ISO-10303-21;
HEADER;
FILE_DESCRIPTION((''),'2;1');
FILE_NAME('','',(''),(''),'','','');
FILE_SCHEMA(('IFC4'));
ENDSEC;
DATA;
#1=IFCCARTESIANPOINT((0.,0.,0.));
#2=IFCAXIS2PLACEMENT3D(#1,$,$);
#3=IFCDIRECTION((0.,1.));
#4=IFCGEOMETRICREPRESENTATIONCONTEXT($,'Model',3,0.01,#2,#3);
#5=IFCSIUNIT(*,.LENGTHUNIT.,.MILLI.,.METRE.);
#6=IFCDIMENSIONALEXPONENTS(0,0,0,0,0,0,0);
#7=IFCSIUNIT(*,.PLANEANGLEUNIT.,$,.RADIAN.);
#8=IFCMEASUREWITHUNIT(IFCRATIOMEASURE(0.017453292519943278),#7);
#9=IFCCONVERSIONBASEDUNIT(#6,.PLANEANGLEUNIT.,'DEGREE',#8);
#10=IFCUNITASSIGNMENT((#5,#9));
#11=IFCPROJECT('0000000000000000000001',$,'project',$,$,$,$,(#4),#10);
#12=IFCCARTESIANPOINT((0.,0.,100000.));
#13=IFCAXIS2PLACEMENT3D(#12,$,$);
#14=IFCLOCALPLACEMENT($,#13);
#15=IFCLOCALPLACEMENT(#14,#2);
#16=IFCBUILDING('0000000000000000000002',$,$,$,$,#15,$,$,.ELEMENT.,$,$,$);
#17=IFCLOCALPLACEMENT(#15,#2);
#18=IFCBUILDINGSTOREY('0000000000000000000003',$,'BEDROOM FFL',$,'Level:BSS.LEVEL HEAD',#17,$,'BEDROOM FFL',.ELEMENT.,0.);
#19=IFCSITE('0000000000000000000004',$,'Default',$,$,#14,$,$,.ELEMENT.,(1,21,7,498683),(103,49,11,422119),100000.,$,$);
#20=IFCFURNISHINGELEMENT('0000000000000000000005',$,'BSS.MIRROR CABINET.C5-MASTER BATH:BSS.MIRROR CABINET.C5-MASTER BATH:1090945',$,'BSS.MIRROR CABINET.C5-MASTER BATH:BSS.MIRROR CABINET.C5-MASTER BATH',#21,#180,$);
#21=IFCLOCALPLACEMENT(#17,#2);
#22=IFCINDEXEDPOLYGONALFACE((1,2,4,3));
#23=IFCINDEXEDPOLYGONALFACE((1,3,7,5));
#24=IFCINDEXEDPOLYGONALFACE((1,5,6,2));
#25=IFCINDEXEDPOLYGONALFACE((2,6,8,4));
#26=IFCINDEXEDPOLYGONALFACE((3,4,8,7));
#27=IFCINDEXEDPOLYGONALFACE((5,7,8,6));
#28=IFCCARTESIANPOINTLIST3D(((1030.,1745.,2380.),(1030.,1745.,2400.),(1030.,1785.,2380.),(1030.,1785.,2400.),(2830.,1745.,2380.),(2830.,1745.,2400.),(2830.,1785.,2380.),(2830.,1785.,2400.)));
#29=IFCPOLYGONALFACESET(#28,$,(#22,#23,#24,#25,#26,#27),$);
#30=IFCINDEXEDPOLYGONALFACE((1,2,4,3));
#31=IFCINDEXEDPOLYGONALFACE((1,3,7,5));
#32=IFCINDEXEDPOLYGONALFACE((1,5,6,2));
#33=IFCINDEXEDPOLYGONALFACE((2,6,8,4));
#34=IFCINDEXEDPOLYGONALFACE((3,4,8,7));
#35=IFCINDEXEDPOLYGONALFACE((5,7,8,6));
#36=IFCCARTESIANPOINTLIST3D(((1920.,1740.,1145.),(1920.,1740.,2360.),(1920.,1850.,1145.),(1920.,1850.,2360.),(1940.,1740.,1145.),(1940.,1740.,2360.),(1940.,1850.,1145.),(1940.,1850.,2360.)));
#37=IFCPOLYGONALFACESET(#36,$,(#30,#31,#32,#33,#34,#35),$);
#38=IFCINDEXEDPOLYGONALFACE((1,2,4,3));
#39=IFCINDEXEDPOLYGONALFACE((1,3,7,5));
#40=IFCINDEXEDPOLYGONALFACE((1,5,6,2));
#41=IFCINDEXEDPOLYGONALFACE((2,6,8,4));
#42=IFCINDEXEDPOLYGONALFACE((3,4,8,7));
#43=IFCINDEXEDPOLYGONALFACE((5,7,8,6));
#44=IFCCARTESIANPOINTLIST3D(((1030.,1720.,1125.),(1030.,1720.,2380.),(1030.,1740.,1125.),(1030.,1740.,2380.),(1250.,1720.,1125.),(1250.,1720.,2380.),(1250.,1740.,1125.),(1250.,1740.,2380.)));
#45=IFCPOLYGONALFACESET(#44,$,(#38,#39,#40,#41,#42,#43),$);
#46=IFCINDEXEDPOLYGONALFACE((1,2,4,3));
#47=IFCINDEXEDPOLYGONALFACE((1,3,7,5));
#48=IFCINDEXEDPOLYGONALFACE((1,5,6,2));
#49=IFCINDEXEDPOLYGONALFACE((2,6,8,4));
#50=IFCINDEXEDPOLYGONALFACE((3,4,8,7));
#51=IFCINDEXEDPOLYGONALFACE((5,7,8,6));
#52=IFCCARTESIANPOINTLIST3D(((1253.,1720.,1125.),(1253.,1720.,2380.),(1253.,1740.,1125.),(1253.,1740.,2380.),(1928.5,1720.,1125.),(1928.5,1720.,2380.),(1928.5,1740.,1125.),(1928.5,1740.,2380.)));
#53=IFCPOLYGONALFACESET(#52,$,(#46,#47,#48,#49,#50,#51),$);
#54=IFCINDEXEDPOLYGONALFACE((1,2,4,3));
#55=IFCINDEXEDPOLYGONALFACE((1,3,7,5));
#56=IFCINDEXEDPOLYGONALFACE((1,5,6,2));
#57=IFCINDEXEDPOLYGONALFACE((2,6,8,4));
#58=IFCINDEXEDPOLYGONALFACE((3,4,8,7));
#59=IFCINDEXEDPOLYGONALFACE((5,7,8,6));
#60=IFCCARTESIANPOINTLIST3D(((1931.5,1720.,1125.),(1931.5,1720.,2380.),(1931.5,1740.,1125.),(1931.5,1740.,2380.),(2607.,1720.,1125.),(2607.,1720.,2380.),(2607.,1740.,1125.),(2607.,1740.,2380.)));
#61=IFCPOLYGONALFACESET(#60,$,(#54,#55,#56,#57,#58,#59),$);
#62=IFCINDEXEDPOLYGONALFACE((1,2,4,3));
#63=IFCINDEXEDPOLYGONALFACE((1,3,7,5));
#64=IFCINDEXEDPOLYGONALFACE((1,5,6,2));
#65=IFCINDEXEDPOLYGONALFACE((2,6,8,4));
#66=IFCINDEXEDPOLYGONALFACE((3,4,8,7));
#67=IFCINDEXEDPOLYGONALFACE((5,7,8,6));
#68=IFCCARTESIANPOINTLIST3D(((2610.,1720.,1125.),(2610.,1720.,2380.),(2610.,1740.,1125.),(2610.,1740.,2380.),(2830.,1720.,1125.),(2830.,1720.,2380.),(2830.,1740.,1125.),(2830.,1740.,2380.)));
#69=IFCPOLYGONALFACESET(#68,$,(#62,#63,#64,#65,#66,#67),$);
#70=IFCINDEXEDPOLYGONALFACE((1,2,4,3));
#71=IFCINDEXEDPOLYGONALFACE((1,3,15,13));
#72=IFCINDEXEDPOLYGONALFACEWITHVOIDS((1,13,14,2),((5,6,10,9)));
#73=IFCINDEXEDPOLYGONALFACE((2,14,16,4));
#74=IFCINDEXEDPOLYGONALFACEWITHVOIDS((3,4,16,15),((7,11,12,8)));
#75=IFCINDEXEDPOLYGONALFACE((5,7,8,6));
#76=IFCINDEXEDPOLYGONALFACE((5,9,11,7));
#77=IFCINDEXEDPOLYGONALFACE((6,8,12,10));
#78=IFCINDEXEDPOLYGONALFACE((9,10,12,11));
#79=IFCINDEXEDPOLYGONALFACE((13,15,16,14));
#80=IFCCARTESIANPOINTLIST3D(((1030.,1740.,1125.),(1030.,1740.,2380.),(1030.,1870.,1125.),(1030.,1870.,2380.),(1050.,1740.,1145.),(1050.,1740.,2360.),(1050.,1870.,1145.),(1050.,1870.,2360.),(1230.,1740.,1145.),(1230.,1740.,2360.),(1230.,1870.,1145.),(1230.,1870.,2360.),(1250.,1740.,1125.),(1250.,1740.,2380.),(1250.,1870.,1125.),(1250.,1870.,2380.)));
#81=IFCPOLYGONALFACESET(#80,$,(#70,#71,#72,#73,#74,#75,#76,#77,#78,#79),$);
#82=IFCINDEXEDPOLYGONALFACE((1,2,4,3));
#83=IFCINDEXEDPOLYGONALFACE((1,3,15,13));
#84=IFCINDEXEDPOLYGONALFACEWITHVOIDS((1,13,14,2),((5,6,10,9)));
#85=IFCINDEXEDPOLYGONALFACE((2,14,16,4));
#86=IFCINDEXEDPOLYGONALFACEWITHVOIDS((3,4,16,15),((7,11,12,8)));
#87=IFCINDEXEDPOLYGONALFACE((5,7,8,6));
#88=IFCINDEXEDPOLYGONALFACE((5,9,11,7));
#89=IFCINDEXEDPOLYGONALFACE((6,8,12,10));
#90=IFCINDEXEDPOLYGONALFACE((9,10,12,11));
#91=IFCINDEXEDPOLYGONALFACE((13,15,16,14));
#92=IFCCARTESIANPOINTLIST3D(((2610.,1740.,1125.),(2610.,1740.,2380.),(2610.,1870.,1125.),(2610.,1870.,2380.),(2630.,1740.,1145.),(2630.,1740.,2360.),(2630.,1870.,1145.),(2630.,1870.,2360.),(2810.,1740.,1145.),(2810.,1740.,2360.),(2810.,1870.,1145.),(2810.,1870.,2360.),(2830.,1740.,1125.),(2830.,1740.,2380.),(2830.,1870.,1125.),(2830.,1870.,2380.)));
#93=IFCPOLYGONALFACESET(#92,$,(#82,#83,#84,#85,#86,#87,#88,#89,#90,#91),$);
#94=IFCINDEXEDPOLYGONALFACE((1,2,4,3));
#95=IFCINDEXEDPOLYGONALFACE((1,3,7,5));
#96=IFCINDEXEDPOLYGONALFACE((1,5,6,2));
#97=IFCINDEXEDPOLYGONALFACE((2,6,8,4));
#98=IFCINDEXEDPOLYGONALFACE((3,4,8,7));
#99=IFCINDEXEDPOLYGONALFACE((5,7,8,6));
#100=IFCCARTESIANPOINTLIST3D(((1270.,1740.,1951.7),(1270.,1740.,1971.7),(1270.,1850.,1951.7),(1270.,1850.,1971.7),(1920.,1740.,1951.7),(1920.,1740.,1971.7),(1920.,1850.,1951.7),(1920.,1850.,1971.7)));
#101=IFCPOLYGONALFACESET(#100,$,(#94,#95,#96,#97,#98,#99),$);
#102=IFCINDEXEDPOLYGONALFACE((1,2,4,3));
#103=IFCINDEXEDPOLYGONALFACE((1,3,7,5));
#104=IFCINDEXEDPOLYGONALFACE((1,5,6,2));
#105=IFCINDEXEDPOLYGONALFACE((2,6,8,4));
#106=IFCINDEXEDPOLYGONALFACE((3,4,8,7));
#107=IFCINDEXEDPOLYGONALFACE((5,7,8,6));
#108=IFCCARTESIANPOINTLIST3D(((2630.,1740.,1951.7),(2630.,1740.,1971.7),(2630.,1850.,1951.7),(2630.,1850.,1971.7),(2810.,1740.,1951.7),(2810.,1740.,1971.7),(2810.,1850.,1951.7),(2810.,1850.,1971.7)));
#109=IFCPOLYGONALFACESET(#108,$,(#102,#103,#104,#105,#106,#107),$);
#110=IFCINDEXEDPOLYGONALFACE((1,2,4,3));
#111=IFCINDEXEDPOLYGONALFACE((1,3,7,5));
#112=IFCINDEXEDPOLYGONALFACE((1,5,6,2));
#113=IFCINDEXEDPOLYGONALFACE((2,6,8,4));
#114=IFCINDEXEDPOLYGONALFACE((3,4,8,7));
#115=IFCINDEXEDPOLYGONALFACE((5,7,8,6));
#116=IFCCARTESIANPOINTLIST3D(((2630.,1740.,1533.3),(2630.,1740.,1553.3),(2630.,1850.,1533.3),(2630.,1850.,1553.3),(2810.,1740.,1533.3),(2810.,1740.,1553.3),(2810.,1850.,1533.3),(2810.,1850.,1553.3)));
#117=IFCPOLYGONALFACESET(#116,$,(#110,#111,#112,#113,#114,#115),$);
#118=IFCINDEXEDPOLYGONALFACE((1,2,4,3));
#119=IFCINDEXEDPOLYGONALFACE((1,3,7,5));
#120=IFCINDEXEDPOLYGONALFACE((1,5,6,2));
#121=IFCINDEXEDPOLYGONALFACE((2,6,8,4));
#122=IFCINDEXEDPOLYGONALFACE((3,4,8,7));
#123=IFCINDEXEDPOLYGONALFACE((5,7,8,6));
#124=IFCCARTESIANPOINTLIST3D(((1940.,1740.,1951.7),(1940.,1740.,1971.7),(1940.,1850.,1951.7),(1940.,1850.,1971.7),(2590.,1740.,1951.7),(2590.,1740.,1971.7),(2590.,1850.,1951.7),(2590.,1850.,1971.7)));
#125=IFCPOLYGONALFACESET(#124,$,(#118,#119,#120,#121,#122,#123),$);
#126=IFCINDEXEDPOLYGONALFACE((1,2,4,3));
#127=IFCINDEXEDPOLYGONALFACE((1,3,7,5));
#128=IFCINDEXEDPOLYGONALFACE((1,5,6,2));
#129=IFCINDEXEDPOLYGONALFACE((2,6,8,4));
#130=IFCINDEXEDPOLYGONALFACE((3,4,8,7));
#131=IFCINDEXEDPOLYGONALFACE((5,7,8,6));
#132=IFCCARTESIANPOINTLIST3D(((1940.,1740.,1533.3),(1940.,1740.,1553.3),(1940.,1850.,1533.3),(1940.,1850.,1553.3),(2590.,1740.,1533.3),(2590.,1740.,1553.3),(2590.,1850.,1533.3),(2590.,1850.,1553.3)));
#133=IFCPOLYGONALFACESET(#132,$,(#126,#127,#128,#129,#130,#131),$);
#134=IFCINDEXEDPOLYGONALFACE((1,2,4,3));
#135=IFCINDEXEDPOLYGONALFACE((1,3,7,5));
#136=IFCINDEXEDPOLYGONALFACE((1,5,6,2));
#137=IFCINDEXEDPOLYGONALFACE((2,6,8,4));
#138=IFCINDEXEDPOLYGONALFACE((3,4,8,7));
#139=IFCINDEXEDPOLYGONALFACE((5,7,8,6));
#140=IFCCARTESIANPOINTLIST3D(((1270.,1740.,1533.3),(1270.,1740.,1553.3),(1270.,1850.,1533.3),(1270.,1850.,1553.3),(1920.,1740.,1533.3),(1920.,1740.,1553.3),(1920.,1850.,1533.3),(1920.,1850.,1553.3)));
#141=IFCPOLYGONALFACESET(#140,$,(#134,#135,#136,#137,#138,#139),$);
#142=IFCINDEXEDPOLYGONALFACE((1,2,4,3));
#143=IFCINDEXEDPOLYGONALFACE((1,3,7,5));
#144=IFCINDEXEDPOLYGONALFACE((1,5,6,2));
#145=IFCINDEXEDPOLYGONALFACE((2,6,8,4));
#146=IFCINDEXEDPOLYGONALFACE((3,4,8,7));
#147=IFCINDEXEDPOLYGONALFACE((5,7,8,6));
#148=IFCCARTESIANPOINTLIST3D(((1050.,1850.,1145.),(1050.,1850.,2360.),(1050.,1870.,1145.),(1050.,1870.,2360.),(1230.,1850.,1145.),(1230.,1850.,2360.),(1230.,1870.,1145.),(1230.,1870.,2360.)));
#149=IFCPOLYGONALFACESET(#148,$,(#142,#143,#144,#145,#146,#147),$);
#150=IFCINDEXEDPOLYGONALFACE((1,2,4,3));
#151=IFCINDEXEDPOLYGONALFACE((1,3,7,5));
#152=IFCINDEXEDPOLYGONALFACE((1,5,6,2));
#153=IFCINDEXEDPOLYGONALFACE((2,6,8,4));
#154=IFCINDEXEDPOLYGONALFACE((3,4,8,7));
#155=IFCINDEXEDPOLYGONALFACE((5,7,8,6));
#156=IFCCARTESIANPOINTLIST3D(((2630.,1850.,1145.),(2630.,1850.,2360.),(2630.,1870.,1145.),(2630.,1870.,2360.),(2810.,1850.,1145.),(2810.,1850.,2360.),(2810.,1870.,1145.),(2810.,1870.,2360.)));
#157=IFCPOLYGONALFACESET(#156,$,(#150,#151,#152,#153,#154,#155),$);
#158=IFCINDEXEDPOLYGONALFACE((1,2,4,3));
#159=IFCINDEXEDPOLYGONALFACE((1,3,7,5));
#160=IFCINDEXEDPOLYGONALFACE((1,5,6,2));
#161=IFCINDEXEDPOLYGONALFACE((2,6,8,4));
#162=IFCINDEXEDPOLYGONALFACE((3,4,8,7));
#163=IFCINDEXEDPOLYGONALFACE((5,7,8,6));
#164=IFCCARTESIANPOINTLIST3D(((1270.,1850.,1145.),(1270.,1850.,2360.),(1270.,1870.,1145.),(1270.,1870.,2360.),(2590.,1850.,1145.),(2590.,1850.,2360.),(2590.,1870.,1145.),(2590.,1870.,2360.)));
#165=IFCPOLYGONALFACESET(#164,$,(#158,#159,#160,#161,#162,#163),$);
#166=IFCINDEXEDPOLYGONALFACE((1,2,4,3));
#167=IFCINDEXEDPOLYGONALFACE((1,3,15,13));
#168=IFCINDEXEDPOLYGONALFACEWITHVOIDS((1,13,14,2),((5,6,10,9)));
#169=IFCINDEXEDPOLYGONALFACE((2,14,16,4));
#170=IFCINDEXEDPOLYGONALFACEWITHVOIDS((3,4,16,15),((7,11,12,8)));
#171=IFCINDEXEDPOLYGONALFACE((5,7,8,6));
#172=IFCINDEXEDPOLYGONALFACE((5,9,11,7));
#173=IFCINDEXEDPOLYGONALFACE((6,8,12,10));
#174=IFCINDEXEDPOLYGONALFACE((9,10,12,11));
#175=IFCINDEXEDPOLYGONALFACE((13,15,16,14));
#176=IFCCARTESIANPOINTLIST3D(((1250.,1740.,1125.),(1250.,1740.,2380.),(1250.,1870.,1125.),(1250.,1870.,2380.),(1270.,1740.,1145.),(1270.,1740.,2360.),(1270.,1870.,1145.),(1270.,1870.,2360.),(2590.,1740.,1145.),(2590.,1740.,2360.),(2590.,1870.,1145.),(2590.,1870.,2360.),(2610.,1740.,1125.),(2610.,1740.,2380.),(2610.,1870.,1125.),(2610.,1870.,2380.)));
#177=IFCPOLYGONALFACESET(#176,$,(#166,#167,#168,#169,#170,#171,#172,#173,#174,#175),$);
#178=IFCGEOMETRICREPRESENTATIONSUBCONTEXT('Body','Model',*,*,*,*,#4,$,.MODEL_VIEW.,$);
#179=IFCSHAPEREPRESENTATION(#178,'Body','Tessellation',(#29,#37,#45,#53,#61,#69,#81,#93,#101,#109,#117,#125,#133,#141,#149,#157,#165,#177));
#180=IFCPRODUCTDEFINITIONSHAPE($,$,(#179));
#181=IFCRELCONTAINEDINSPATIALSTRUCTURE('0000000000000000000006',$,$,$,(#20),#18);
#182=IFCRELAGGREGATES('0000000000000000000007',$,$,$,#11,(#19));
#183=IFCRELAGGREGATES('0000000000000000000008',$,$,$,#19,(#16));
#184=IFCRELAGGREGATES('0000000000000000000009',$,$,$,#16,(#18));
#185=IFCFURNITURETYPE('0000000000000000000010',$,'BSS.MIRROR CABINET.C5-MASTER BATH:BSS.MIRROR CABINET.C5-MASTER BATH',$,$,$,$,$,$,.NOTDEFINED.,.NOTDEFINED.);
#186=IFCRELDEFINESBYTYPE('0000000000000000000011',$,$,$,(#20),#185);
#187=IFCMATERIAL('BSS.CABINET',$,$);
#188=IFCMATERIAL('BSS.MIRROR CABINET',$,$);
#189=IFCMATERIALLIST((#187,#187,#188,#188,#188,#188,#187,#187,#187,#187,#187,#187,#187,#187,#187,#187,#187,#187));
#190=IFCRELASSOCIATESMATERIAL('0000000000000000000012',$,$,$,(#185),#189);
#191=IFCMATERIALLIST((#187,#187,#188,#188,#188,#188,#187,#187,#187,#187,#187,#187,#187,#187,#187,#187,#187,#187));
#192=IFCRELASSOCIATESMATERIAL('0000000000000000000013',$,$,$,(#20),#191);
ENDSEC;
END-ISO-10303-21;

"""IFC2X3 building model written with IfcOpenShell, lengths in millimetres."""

from ifc_helpers import new_model, entity, si_unit, converted_unit, direction, frame, frame_2d, origin, origin_2d_with_axis, place, context, subcontext, project, spatial, polyline, rectangle, outline, extrude, source, transform, mapped, material, material_list, type_object, type_shapes, element, save


model = new_model("IFC2X3")

# Units and contexts
model_context = context("Model", 3, precision=0.01, world=origin(), true_north=direction((0.0, 1.0)))
body_context = subcontext(model_context, "Body", "Model", "MODEL_VIEW")
ifc_project = project(units=[si_unit("LENGTHUNIT", "METRE", prefix="MILLI"), converted_unit("PLANEANGLEUNIT", "DEGREE", entity("IfcRatioMeasure", 0.017453292519943278), si_unit("PLANEANGLEUNIT", "RADIAN"), dimensions=[0, 0, 0, 0, 0, 0, 0])], contexts=[model_context])

# Site, building, storey
site_placement = place(None, frame((0.0, 0.0, 100000.0)))
site = spatial("IfcSite", under=ifc_project, at=site_placement, Name="Default", CompositionType="ELEMENT", RefLatitude=(1, 21, 7, 498683), RefLongitude=(103, 49, 11, 422119), RefElevation=100000.0)
building_placement = place(site_placement, origin())
building = spatial("IfcBuilding", under=site, at=building_placement, CompositionType="ELEMENT")
storey_placement = place(building_placement, origin())
storey = spatial("IfcBuildingStorey", under=building, at=storey_placement, Name="BEDROOM FFL", ObjectType="Level:BSS.LEVEL HEAD", LongName="BEDROOM FFL", CompositionType="ELEMENT", Elevation=0.0)

# Furnishing element
ifc_material_1 = material(Name="BSS.CABINET")
ifc_material_2 = material(Name="BSS.MIRROR CABINET")
ifc_material_list_1 = material_list([ifc_material_1, ifc_material_1, ifc_material_2, ifc_material_2, ifc_material_2, ifc_material_2, ifc_material_1, ifc_material_1, ifc_material_1, ifc_material_1, ifc_material_1, ifc_material_1, ifc_material_1, ifc_material_1, ifc_material_1, ifc_material_1, ifc_material_1, ifc_material_1])
ifc_material_list_2 = material_list([ifc_material_1, ifc_material_1, ifc_material_2, ifc_material_2, ifc_material_2, ifc_material_2, ifc_material_1, ifc_material_1, ifc_material_1, ifc_material_1, ifc_material_1, ifc_material_1, ifc_material_1, ifc_material_1, ifc_material_1, ifc_material_1, ifc_material_1, ifc_material_1])
furniture_type = type_object("IfcFurnitureType", Name="BSS.MIRROR CABINET.C5-MASTER BATH:BSS.MIRROR CABINET.C5-MASTER BATH", material=ifc_material_list_2)
shared_shape_1 = source(origin(), body_context, "Body", "SweptSolid", [
    extrude(rectangle(XDim=40.0, YDim=1800.0, at=frame_2d((0.0, 0.0), x_axis=(1.0, 0.0))), frame((0.0, 105.0, 1255.0), z_axis=(0.0, 0.0, 1.0), x_axis=(0.0, 1.0, 0.0)), (0.0, 0.0, 1.0), 20.0),
    extrude(rectangle(XDim=20.0, YDim=110.0, at=frame_2d((0.0, 0.0), x_axis=(1.0, 0.0))), frame((0.0, 75.0, 20.0), z_axis=(0.0, 0.0, 1.0), x_axis=(-1.0, 0.0, 0.0)), (0.0, 0.0, 1.0), 1215.0),
    extrude(rectangle(XDim=220.0, YDim=20.0, at=frame_2d((0.0, 0.0), x_axis=(1.0, 0.0))), frame((790.0, 140.0, 0.0), z_axis=(0.0, 0.0, 1.0), x_axis=(-1.0, 0.0, 0.0)), (0.0, 0.0, 1.0), 1255.0),
    extrude(rectangle(XDim=675.5, YDim=20.0, at=frame_2d((0.0, 0.0), x_axis=(1.0, 0.0))), frame((339.2, 140.0, 0.0), z_axis=(0.0, 0.0, 1.0), x_axis=(-1.0, 0.0, 0.0)), (0.0, 0.0, 1.0), 1255.0),
    extrude(rectangle(XDim=675.5, YDim=20.0, at=frame_2d((0.0, 0.0), x_axis=(1.0, 0.0))), frame((-339.3, 140.0, 0.0), z_axis=(0.0, 0.0, 1.0), x_axis=(-1.0, 0.0, 0.0)), (0.0, 0.0, 1.0), 1255.0),
    extrude(rectangle(XDim=220.0, YDim=20.0, at=frame_2d((0.0, 0.0), x_axis=(1.0, 0.0))), frame((-790.0, 140.0, 0.0), z_axis=(0.0, 0.0, 1.0), x_axis=(-1.0, 0.0, 0.0)), (0.0, 0.0, 1.0), 1255.0),
    extrude(outline(polyline([(-627.5, -110.0), (627.5, -110.0), (627.5, 110.0), (-627.5, 110.0), (-627.5, -110.0)]), holes=[polyline([(607.5, 90.0), (607.5, -90.0), (-607.5, -90.0), (-607.5, 90.0), (607.5, 90.0)])]), frame((790.0, 0.0, 627.5), z_axis=(0.0, 1.0, 0.0), x_axis=(0.0, 0.0, -1.0)), (0.0, 0.0, 1.0), 130.0),
    extrude(outline(polyline([(-627.5, -110.0), (627.5, -110.0), (627.5, 110.0), (-627.5, 110.0), (-627.5, -110.0)]), holes=[polyline([(607.5, 90.0), (607.5, -90.0), (-607.5, -90.0), (-607.5, 90.0), (607.5, 90.0)])]), frame((-790.0, 0.0, 627.5), z_axis=(0.0, 1.0, 0.0), x_axis=(0.0, 0.0, -1.0)), (0.0, 0.0, 1.0), 130.0),
    extrude(rectangle(XDim=650.0, YDim=110.0, at=origin_2d_with_axis()), frame((335.0, 75.0, 826.7), z_axis=(0.0, 0.0, 1.0), x_axis=(-1.0, 0.0, 0.0)), (0.0, 0.0, 1.0), 20.0),
    extrude(rectangle(XDim=180.0, YDim=110.0, at=origin_2d_with_axis()), frame((-790.0, 75.0, 826.7), z_axis=(0.0, 0.0, 1.0), x_axis=(-1.0, 0.0, 0.0)), (0.0, 0.0, 1.0), 20.0),
    extrude(rectangle(XDim=180.0, YDim=110.0, at=origin_2d_with_axis()), frame((-790.0, 75.0, 408.3), z_axis=(0.0, 0.0, 1.0), x_axis=(-1.0, 0.0, 0.0)), (0.0, 0.0, 1.0), 20.0),
    extrude(rectangle(XDim=650.0, YDim=110.0, at=origin_2d_with_axis()), frame((-335.0, 75.0, 826.7), z_axis=(0.0, 0.0, 1.0), x_axis=(-1.0, 0.0, 0.0)), (0.0, 0.0, 1.0), 20.0),
    extrude(rectangle(XDim=650.0, YDim=110.0, at=frame_2d((0.0, 0.0), x_axis=(1.0, 0.0))), frame((-335.0, 75.0, 408.3), z_axis=(0.0, 0.0, 1.0), x_axis=(-1.0, 0.0, 0.0)), (0.0, 0.0, 1.0), 20.0),
    extrude(rectangle(XDim=650.0, YDim=110.0, at=origin_2d_with_axis()), frame((335.0, 75.0, 408.3), z_axis=(0.0, 0.0, 1.0), x_axis=(-1.0, 0.0, 0.0)), (0.0, 0.0, 1.0), 20.0),
    extrude(rectangle(XDim=180.0, YDim=20.0, at=origin_2d_with_axis()), frame((790.0, 10.0, 20.0), z_axis=(0.0, 0.0, 1.0), x_axis=(-1.0, 0.0, 0.0)), (0.0, 0.0, 1.0), 1215.0),
    extrude(rectangle(XDim=180.0, YDim=20.0, at=origin_2d_with_axis()), frame((-790.0, 10.0, 20.0), z_axis=(0.0, 0.0, 1.0), x_axis=(-1.0, 0.0, 0.0)), (0.0, 0.0, 1.0), 1215.0),
    extrude(rectangle(XDim=1320.0, YDim=20.0, at=origin_2d_with_axis()), frame((0.0, 10.0, 20.0), z_axis=(0.0, 0.0, 1.0), x_axis=(-1.0, 0.0, 0.0)), (0.0, 0.0, 1.0), 1215.0),
    extrude(outline(polyline([(-680.0, -627.5), (680.0, -627.5), (680.0, 627.5), (-680.0, 627.5), (-680.0, -627.5)]), holes=[polyline([(660.0, 607.5), (660.0, -607.5), (-660.0, -607.5), (-660.0, 607.5), (660.0, 607.5)])]), frame((0.0, 0.0, 627.5), z_axis=(0.0, 1.0, 0.0), x_axis=(-1.0, 0.0, 0.0)), (0.0, 0.0, 1.0), 130.0),
])
type_shapes(furniture_type, [shared_shape_1])
furnishing_placement = place(storey_placement, frame((1930.0, 1870.0, 1125.0), z_axis=(0.0, 0.0, 1.0), x_axis=(-1.0, 0.0, 0.0)))
element("IfcFurnishingElement", 1, at=furnishing_placement, inside=storey, type_object=furniture_type, material=ifc_material_list_1, Name="BSS.MIRROR CABINET.C5-MASTER BATH:BSS.MIRROR CABINET.C5-MASTER BATH:1090945", ObjectType="BSS.MIRROR CABINET.C5-MASTER BATH:BSS.MIRROR CABINET.C5-MASTER BATH", context=body_context, shape_type="MappedRepresentation", body=[
    mapped(shared_shape_1, transform((0.0, 0.0, 0.0), scale=1.0)),
])

save(model, "model.ifc")
